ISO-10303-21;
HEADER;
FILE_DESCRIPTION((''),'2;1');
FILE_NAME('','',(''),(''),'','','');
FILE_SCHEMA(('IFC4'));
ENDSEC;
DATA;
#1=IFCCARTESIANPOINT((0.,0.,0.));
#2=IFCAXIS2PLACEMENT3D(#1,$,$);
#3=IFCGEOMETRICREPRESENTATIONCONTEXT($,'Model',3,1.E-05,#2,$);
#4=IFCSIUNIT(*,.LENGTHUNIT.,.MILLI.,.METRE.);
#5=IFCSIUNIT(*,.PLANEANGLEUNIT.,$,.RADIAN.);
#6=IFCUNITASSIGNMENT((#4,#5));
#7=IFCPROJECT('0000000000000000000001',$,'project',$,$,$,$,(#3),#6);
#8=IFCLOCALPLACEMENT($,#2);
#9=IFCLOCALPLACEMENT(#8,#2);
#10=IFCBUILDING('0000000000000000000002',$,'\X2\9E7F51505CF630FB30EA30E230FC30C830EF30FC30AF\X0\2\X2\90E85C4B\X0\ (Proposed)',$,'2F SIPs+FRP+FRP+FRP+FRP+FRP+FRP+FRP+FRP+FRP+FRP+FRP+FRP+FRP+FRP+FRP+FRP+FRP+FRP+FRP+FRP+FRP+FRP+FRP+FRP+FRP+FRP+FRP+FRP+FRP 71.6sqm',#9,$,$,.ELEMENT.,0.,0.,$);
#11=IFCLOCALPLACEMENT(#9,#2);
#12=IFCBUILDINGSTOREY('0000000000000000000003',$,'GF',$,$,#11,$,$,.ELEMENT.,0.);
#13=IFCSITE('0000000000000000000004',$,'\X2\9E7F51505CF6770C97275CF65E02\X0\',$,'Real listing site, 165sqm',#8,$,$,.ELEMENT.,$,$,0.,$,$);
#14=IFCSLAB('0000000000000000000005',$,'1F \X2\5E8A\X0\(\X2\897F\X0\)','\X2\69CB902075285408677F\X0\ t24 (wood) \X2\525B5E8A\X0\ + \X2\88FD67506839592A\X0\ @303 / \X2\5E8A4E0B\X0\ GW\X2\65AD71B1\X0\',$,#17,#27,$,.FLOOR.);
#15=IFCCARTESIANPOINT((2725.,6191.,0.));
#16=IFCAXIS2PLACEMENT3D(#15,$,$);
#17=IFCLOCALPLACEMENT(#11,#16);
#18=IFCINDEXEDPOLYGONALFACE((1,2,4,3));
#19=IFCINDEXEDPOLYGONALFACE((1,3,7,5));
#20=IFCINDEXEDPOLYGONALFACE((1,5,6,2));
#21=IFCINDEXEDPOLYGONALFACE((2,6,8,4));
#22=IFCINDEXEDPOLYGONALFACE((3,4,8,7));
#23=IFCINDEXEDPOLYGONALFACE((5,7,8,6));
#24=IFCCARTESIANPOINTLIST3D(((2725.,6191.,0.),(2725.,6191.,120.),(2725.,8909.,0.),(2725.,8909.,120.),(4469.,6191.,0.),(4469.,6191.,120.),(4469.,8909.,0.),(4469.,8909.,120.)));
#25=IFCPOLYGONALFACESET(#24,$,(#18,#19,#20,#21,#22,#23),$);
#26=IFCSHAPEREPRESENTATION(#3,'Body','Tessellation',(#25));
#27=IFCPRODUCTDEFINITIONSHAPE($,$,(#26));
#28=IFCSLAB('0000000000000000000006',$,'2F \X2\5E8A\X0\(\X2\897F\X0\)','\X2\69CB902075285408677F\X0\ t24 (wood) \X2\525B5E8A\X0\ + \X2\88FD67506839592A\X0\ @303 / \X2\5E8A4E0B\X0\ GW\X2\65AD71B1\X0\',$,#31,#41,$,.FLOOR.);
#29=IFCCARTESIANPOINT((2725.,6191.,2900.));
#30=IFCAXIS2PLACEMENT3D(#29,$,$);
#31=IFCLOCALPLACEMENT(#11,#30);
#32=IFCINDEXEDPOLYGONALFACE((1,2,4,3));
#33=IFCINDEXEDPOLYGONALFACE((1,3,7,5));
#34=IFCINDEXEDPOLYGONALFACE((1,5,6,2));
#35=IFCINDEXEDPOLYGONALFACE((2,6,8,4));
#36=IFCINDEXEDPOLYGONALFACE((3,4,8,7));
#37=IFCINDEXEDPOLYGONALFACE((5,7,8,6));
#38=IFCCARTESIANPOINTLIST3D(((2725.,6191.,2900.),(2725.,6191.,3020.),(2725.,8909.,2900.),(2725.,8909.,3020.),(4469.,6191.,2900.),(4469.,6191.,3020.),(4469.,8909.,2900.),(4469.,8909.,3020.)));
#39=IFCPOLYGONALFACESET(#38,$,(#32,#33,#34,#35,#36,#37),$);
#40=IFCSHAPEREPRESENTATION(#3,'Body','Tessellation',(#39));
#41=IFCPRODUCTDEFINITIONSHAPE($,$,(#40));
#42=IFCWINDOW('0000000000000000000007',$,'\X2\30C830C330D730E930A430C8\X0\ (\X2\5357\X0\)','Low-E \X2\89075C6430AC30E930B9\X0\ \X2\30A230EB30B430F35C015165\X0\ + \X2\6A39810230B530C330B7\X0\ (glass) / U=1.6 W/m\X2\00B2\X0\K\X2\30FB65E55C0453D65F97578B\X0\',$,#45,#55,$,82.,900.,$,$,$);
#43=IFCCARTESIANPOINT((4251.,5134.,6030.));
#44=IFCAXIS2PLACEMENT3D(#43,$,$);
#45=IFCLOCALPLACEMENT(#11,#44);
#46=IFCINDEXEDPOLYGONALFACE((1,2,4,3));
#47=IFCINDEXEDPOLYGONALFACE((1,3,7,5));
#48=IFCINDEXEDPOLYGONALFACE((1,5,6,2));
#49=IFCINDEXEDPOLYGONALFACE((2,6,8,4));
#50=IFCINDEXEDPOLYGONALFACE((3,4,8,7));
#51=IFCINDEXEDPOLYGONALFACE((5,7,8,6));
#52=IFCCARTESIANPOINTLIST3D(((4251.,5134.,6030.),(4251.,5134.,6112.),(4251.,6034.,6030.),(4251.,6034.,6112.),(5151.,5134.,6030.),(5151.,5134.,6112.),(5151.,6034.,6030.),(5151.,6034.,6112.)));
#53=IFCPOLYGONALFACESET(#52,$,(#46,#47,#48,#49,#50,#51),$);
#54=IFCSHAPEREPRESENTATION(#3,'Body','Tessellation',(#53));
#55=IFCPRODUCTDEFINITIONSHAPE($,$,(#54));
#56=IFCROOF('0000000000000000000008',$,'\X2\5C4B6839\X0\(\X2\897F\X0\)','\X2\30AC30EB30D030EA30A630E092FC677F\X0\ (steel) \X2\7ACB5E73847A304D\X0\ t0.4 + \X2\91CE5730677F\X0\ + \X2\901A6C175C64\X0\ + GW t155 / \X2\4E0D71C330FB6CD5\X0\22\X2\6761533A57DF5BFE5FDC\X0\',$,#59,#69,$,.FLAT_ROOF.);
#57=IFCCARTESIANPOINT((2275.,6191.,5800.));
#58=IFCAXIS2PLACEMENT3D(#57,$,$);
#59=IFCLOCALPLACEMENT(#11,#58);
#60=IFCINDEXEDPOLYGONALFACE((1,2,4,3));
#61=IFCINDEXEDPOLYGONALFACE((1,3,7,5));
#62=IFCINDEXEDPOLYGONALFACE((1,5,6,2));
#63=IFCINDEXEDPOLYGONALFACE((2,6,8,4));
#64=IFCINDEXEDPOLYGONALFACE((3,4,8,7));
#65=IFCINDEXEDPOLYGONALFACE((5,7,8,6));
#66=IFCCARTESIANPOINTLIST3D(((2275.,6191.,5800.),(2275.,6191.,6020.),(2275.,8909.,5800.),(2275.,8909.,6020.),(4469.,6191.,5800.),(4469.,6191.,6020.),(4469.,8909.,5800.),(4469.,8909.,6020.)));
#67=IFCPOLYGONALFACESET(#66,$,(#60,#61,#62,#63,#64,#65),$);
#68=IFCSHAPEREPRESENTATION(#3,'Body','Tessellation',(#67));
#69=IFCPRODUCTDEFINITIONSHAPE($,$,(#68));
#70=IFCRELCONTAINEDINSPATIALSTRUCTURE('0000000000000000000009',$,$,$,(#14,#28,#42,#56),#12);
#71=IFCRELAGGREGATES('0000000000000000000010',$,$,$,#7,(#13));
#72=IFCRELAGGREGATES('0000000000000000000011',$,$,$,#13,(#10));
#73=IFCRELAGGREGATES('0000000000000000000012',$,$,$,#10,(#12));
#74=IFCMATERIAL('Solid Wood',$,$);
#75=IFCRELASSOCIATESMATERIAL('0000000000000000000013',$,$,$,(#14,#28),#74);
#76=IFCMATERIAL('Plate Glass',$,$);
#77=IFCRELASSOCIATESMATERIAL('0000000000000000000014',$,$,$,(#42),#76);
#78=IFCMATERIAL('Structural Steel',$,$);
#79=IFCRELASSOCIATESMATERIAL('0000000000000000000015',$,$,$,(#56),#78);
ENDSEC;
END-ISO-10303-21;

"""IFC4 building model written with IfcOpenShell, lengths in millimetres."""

from ifc_helpers import new_model, si_unit, frame, frame_2d, origin, place, context, project, spatial, rectangle, extrude, material, element, save


model = new_model("IFC4")

# Units and contexts
model_context = context("Model", 3, precision=1e-05, world=origin())
ifc_project = project(units=[si_unit("LENGTHUNIT", "METRE", prefix="MILLI"), si_unit("PLANEANGLEUNIT", "RADIAN")], contexts=[model_context])

# Site, building, storey
site_placement = place(None, origin())
site = spatial("IfcSite", under=ifc_project, at=site_placement, Name="鹿児島県霧島市", ObjectType="Real listing site, 165sqm", CompositionType="ELEMENT", RefElevation=0.0)
building_placement = place(site_placement, origin())
building = spatial("IfcBuilding", under=site, at=building_placement, Name="鹿児島・リモートワーク2部屋 (Proposed)", ObjectType="2F SIPs+FRP+FRP+FRP+FRP+FRP+FRP+FRP+FRP+FRP+FRP+FRP+FRP+FRP+FRP+FRP+FRP+FRP+FRP+FRP+FRP+FRP+FRP+FRP+FRP+FRP+FRP+FRP+FRP+FRP 71.6sqm", CompositionType="ELEMENT", ElevationOfRefHeight=0.0, ElevationOfTerrain=0.0)
storey_placement = place(building_placement, origin())
storey = spatial("IfcBuildingStorey", under=building, at=storey_placement, Name="GF", CompositionType="ELEMENT", Elevation=0.0)

# Shared definitions
ifc_material_1 = material(Name="Solid Wood")

# Slabs
slab_1_placement = place(storey_placement, frame((2725.0, 6191.0, 0.0)))
element("IfcSlab", 1, at=slab_1_placement, inside=storey, material=ifc_material_1, Name="1F 床(西)", Description="構造用合板 t24 (wood) 剛床 + 製材根太 @303 / 床下 GW断熱", PredefinedType="FLOOR", context=model_context, shape_type="SweptSolid", body=[
    extrude(rectangle(XDim=1744.0, YDim=2718.0, at=frame_2d((872.0, 1359.0))), frame((2725.0, 6191.0, 0.0)), (0.0, 0.0, 1.0), 120.0),
])
slab_2_placement = place(storey_placement, frame((2725.0, 6191.0, 2900.0)))
element("IfcSlab", 2, at=slab_2_placement, inside=storey, material=ifc_material_1, Name="2F 床(西)", Description="構造用合板 t24 (wood) 剛床 + 製材根太 @303 / 床下 GW断熱", PredefinedType="FLOOR", context=model_context, shape_type="SweptSolid", body=[
    extrude(rectangle(XDim=1744.0, YDim=2718.0, at=frame_2d((872.0, 1359.0))), frame((2725.0, 6191.0, 2900.0)), (0.0, 0.0, 1.0), 120.0),
])

# Window
ifc_material_2 = material(Name="Plate Glass")
window_placement = place(storey_placement, frame((4251.0, 5134.0, 6030.0)))
element("IfcWindow", 3, at=window_placement, inside=storey, material=ifc_material_2, Name="トップライト (南)", Description="Low-E 複層ガラス アルゴン封入 + 樹脂サッシ (glass) / U=1.6 W/m²K・日射取得型", OverallHeight=82.0, OverallWidth=900.0, context=model_context, shape_type="SweptSolid", body=[
    extrude(rectangle(XDim=900.0, YDim=900.0, at=frame_2d((450.0, 450.0))), frame((4251.0, 5134.0, 6030.0)), (0.0, 0.0, 1.0), 82.0),
])

# Roof
ifc_material_3 = material(Name="Structural Steel")
for number, where, name in (
    (4, (2275.0, 6191.0, 5800.0), "屋根(西)"),
):
    element("IfcRoof", number, at=place(storey_placement, frame(where)), inside=storey, material=ifc_material_3, Name=name, Description="ガルバリウム鋼板 (steel) 立平葺き t0.4 + 野地板 + 通気層 + GW t155 / 不燃・法22条区域対応", PredefinedType="FLAT_ROOF", context=model_context, shape_type="SweptSolid", body=[
        extrude(rectangle(XDim=2194.0, YDim=2718.0, at=frame_2d((1097.0, 1359.0))), frame((2275.0, 6191.0, 5800.0)), (0.0, 0.0, 1.0), 220.0),
    ])

save(model, "model.ifc")
